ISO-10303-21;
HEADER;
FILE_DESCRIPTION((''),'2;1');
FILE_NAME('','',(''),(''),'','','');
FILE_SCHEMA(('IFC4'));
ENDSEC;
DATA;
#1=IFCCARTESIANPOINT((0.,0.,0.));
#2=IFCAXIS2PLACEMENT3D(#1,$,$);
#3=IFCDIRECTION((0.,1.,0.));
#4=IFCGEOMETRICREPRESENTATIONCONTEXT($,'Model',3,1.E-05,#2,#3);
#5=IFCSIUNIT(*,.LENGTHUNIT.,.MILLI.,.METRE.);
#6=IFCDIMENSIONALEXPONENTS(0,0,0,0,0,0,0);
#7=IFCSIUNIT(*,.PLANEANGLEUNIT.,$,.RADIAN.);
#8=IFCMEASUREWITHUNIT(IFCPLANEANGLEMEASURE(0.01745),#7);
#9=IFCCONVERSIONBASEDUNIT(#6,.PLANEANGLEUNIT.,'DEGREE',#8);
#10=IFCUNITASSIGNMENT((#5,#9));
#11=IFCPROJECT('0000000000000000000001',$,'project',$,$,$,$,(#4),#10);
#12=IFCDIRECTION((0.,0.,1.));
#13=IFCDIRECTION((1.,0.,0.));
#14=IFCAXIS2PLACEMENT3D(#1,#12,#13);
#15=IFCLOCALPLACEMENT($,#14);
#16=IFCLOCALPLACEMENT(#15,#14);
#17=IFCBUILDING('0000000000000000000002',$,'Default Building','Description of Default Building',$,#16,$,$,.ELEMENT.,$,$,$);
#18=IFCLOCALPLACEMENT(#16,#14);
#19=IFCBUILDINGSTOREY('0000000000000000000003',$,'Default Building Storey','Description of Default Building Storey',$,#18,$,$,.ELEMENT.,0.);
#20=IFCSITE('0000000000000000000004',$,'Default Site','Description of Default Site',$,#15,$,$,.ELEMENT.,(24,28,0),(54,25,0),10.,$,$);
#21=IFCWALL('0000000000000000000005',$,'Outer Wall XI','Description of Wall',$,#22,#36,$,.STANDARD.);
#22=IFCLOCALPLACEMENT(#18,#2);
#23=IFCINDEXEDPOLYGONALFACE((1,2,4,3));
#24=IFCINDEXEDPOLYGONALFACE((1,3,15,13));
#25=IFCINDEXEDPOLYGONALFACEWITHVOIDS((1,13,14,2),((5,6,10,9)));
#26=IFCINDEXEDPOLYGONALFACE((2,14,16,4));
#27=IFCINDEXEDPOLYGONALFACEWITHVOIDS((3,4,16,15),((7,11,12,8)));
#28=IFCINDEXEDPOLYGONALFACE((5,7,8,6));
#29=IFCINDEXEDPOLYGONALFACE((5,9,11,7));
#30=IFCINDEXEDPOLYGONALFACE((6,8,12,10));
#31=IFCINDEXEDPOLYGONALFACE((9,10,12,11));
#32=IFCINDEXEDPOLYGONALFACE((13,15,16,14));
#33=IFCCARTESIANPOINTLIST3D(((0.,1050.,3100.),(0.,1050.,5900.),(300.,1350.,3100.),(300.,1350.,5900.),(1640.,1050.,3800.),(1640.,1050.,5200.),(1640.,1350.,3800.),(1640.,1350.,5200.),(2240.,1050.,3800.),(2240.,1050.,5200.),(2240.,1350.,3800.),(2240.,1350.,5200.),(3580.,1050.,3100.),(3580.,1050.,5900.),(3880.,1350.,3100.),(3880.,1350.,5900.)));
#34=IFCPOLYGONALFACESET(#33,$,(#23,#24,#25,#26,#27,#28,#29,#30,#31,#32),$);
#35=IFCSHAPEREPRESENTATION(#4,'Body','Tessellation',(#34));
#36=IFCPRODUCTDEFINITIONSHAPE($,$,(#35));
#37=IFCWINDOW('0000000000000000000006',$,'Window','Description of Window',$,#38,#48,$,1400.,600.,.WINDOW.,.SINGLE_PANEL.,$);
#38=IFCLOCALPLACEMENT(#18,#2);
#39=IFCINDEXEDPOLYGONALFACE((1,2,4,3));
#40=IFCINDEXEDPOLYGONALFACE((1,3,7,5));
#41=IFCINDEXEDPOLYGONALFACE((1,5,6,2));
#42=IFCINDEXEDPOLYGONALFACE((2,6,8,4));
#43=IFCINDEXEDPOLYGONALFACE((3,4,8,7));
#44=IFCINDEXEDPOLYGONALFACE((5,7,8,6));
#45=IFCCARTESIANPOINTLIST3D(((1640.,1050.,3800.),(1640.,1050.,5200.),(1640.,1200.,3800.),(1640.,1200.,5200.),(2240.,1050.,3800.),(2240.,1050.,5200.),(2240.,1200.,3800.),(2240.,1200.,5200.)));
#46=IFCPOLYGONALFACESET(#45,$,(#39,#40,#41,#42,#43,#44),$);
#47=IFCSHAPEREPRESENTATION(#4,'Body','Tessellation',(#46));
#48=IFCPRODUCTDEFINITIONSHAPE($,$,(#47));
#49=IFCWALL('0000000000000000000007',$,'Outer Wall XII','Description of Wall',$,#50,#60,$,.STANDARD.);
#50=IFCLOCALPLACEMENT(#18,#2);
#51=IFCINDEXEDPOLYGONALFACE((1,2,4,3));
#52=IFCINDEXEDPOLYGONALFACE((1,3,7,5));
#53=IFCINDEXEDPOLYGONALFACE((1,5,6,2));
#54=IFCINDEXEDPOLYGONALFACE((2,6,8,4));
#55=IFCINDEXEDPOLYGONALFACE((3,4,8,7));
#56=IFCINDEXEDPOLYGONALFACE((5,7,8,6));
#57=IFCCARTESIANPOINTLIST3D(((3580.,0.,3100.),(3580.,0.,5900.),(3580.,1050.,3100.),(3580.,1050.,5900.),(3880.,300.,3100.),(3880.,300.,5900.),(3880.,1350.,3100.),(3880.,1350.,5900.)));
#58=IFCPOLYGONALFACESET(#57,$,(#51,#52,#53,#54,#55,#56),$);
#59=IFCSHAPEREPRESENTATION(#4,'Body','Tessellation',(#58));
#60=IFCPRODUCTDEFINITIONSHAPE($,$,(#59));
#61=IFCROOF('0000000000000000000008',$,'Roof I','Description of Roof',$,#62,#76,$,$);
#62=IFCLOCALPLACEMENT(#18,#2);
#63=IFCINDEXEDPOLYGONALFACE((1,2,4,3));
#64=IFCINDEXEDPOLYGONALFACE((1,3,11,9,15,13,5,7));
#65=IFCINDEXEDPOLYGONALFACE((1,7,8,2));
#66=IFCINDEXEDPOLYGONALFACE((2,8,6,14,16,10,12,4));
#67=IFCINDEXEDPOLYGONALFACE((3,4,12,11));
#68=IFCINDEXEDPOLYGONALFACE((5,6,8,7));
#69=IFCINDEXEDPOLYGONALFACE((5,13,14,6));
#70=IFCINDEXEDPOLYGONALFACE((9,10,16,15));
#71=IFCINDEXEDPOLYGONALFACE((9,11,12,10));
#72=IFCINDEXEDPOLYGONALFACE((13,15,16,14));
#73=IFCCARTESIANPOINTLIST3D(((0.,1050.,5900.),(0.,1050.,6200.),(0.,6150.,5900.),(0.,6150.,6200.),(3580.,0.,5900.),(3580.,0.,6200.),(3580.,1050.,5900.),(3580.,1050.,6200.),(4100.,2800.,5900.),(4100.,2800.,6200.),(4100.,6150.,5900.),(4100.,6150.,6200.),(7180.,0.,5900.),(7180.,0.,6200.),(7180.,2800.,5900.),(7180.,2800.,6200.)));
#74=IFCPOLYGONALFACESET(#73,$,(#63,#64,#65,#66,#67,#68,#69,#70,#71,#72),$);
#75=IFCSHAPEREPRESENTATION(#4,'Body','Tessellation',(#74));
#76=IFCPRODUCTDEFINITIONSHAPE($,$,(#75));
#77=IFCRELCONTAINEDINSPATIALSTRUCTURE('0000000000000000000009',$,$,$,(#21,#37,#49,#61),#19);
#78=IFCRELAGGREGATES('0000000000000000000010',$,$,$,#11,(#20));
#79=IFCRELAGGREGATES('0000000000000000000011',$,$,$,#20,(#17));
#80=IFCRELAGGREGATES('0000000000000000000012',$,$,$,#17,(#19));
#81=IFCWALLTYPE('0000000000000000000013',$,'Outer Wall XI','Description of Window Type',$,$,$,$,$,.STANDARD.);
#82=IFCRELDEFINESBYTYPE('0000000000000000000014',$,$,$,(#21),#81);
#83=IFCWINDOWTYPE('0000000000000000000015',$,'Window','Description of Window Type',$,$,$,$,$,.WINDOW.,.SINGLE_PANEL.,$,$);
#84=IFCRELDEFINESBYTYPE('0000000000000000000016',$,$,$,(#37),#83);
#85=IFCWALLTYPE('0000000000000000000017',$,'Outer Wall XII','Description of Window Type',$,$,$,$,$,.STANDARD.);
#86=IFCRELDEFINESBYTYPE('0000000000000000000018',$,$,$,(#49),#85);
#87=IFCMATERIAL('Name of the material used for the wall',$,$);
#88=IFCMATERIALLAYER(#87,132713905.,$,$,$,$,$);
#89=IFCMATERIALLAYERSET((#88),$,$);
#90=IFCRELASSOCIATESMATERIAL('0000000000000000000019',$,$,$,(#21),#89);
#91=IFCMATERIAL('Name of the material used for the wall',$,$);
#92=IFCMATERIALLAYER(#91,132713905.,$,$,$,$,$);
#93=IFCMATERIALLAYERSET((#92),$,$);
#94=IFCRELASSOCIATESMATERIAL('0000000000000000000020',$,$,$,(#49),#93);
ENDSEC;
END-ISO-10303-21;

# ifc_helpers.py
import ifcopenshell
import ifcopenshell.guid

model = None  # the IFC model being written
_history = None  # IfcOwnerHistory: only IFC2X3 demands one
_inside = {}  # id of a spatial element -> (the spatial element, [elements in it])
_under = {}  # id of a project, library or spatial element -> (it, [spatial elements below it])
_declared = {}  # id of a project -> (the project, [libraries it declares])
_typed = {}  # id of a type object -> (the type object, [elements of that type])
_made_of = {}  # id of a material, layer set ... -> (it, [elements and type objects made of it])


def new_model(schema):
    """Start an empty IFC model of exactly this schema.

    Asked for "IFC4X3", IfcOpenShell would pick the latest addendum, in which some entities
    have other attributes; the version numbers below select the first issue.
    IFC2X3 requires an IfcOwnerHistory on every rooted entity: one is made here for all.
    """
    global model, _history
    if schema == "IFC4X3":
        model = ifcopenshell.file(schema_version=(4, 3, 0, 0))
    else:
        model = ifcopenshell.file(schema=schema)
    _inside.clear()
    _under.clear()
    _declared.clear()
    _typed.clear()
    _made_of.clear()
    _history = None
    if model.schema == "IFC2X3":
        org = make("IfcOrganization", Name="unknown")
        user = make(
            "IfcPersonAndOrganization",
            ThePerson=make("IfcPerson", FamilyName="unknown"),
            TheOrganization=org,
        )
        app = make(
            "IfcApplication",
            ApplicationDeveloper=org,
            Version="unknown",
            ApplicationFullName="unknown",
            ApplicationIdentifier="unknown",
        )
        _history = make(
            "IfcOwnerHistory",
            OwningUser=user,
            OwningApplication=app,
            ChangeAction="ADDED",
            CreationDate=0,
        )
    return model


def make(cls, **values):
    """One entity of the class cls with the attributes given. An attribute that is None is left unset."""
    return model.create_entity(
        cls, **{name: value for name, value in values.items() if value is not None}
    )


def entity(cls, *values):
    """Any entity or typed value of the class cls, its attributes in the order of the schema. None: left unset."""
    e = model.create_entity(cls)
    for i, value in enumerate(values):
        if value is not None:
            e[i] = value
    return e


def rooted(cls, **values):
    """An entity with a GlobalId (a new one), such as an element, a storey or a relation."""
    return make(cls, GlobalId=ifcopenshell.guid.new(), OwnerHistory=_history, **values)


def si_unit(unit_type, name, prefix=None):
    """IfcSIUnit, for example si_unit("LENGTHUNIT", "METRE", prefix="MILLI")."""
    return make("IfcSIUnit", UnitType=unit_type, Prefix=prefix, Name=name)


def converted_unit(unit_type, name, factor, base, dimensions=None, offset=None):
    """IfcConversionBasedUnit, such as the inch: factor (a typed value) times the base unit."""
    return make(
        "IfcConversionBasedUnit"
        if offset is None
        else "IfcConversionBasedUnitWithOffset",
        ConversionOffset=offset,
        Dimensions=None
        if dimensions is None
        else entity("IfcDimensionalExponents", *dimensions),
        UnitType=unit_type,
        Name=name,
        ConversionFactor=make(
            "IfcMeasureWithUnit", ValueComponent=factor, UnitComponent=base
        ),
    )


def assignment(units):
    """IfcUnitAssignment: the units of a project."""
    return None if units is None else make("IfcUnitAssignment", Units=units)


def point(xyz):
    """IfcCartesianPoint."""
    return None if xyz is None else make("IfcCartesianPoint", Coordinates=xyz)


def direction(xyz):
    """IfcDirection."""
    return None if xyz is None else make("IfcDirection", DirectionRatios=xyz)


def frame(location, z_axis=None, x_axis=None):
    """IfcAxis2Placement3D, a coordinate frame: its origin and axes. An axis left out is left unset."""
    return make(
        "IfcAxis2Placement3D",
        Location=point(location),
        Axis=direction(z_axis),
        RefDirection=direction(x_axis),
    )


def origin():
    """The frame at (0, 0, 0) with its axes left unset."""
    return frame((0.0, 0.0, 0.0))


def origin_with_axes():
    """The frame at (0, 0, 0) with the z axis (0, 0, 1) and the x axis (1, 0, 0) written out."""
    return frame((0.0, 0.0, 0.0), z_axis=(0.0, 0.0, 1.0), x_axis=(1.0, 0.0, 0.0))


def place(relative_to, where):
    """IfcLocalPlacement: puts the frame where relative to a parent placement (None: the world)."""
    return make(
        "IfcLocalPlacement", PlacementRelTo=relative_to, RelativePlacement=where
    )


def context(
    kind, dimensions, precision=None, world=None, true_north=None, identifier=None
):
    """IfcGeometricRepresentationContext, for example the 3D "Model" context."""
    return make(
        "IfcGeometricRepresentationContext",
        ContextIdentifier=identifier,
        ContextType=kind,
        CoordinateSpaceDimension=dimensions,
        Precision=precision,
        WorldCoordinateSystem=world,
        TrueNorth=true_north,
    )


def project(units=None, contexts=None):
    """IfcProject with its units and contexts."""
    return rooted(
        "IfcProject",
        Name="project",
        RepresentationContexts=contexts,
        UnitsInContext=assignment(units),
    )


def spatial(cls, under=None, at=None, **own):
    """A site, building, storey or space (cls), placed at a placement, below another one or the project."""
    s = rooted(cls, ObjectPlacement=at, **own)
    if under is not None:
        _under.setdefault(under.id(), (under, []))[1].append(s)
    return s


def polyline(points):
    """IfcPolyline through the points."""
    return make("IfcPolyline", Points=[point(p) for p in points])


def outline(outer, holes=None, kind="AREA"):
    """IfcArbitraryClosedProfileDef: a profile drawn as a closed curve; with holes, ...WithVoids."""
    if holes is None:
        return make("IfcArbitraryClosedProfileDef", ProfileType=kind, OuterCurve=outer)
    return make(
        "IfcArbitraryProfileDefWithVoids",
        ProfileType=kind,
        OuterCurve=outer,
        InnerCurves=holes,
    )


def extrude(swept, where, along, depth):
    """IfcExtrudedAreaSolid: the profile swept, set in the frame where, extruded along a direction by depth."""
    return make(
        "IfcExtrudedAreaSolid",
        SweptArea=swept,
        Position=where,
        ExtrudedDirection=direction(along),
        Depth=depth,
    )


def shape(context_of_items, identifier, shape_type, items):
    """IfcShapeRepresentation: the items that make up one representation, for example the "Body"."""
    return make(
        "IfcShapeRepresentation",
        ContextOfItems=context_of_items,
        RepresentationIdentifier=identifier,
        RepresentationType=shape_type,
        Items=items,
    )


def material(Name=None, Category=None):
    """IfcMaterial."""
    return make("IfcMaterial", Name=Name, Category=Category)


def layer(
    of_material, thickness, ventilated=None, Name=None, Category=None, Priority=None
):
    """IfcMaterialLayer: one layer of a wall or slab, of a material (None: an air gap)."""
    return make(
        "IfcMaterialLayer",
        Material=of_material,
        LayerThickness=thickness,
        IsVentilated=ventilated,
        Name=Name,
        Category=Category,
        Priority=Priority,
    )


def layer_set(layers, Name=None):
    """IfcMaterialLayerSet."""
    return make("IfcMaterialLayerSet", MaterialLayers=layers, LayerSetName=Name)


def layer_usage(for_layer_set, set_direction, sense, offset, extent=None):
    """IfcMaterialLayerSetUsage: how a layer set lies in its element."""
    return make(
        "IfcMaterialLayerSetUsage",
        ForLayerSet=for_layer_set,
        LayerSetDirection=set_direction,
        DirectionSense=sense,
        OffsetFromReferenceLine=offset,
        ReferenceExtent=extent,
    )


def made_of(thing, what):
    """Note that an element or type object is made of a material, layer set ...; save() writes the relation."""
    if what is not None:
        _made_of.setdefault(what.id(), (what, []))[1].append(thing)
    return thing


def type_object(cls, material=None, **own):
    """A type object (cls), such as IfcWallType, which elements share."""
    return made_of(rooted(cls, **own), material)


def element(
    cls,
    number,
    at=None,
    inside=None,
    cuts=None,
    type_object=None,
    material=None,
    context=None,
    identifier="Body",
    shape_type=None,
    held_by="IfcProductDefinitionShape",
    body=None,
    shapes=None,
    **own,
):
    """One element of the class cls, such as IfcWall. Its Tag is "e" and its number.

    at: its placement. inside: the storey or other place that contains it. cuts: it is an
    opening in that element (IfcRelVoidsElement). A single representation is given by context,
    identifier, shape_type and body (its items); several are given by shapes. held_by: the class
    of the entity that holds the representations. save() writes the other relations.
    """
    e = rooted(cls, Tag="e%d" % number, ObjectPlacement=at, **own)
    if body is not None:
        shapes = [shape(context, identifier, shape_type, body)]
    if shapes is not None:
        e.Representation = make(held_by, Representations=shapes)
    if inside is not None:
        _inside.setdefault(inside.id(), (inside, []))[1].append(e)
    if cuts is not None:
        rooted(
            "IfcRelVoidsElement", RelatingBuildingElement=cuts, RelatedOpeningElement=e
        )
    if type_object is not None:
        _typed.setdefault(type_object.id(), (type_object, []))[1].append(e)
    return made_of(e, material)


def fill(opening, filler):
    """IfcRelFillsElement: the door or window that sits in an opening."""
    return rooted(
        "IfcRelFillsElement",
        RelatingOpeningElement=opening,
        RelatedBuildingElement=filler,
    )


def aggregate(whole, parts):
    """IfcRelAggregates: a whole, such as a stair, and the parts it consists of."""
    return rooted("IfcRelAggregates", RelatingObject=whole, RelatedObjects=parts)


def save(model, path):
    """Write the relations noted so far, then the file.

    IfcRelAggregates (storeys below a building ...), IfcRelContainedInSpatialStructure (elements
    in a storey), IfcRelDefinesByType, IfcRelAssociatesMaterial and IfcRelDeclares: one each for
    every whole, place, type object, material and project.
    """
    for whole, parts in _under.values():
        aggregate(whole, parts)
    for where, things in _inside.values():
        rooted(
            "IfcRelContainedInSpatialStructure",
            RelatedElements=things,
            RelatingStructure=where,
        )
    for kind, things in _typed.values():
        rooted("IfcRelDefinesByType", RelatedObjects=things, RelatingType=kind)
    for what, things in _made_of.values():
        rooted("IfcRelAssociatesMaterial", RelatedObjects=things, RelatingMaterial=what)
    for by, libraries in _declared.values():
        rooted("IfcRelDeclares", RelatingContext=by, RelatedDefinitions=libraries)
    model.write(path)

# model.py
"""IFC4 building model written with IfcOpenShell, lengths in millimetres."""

from ifc_helpers import new_model, entity, si_unit, converted_unit, direction, frame, origin, origin_with_axes, place, context, project, spatial, polyline, outline, extrude, material, layer, layer_set, layer_usage, type_object, element, fill, save


model = new_model("IFC4")

# Units and contexts
model_context = context("Model", 3, precision=1e-05, world=origin(), true_north=direction((0.0, 1.0, 0.0)))
ifc_project = project(units=[si_unit("LENGTHUNIT", "METRE", prefix="MILLI"), converted_unit("PLANEANGLEUNIT", "DEGREE", entity("IfcPlaneAngleMeasure", 0.01745), si_unit("PLANEANGLEUNIT", "RADIAN"), dimensions=[0, 0, 0, 0, 0, 0, 0])], contexts=[model_context])

# Site, building, storey
site_placement = place(None, origin_with_axes())
site = spatial("IfcSite", under=ifc_project, at=site_placement, Name="Default Site", Description="Description of Default Site", CompositionType="ELEMENT", RefLatitude=(24, 28, 0), RefLongitude=(54, 25, 0), RefElevation=10.0)
building_placement = place(site_placement, origin_with_axes())
building = spatial("IfcBuilding", under=site, at=building_placement, Name="Default Building", Description="Description of Default Building", CompositionType="ELEMENT")
storey_placement = place(building_placement, origin_with_axes())
storey = spatial("IfcBuildingStorey", under=building, at=storey_placement, Name="Default Building Storey", Description="Description of Default Building Storey", CompositionType="ELEMENT", Elevation=0.0)

# Wall, opening, window
ifc_material_1 = material(Name="Name of the material used for the wall")
ifc_layer_1 = layer(ifc_material_1, 132713905.0)
ifc_layer_set_1 = layer_set([ifc_layer_1])
ifc_layer_usage_1 = layer_usage(ifc_layer_set_1, "AXIS2", "POSITIVE", -66356952.5)
wall_type_1 = type_object("IfcWallType", Name="Outer Wall XI", Description="Description of Window Type", PredefinedType="STANDARD")
wall_1_placement = place(storey_placement, frame((150.0, 1200.0, 3100.0), z_axis=(0.0, 0.0, 1.0), x_axis=(1.0, 0.0, 0.0)))
wall_1 = element("IfcWall", 1, at=wall_1_placement, inside=storey, type_object=wall_type_1, material=ifc_layer_usage_1, Name="Outer Wall XI", Description="Description of Wall", PredefinedType="STANDARD", context=model_context, shape_type="SweptSolid", body=[
    extrude(outline(polyline([(-150.0, -150.0), (150.0, 150.0), (3730.0, 150.0), (3430.0, -150.0), (-150.0, -150.0)])), origin_with_axes(), (0.0, 0.0, 1.0), 2800.0),
])
opening_1_placement = place(wall_1_placement, frame((1490.0, -150.0, 700.0), z_axis=(0.0, 0.0, 1.0), x_axis=(1.0, 0.0, 0.0)))
opening_1 = element("IfcOpeningElement", 2, at=opening_1_placement, cuts=wall_1, context=model_context, shape_type="SweptSolid", body=[
    extrude(outline(polyline([(0.0, 0.0), (0.0, 300.0), (600.0, 300.0), (600.0, 0.0), (0.0, 0.0)])), origin_with_axes(), (0.0, 0.0, 1.0), 1400.0),
])
window_type_1 = type_object("IfcWindowType", Name="Window", Description="Description of Window Type", PartitioningType="SINGLE_PANEL", PredefinedType="WINDOW")
window_1_placement = place(opening_1_placement, origin_with_axes())
window_1 = element("IfcWindow", 3, at=window_1_placement, inside=storey, type_object=window_type_1, Name="Window", Description="Description of Window", OverallHeight=1400.0, OverallWidth=600.0, PartitioningType="SINGLE_PANEL", PredefinedType="WINDOW", context=model_context, shape_type="SweptSolid", body=[
    extrude(outline(polyline([(0.0, 0.0), (0.0, 150.0), (600.0, 150.0), (600.0, 0.0), (0.0, 0.0)])), origin_with_axes(), (0.0, 0.0, 1.0), 1400.0),
])
fill(opening_1, window_1)

# Wall
ifc_material_2 = material(Name="Name of the material used for the wall")
ifc_layer_2 = layer(ifc_material_2, 132713905.0)
ifc_layer_set_2 = layer_set([ifc_layer_2])
ifc_layer_usage_2 = layer_usage(ifc_layer_set_2, "AXIS2", "POSITIVE", -66356952.5)
wall_type_2 = type_object("IfcWallType", Name="Outer Wall XII", Description="Description of Window Type", PredefinedType="STANDARD")
wall_2_placement = place(storey_placement, frame((3730.0, 1200.0, 3100.0), z_axis=(0.0, 0.0, 1.0), x_axis=(0.0, -1.0, 0.0)))
element("IfcWall", 4, at=wall_2_placement, inside=storey, type_object=wall_type_2, material=ifc_layer_usage_2, Name="Outer Wall XII", Description="Description of Wall", PredefinedType="STANDARD", context=model_context, shape_type="SweptSolid", body=[
    extrude(outline(polyline([(150.0, -150.0), (-150.0, 150.0), (900.0, 150.0), (1200.0, -150.0), (150.0, -150.0)])), origin_with_axes(), (0.0, 0.0, 1.0), 2800.0),
])

# Roof
roof_placement = place(storey_placement, frame((0.0, 0.0, 5900.0), z_axis=(0.0, 0.0, 1.0), x_axis=(1.0, 0.0, 0.0)))
element("IfcRoof", 5, at=roof_placement, inside=storey, Name="Roof I", Description="Description of Roof", context=model_context, shape_type="SweptSolid", body=[
    extrude(outline(polyline([(0.0, 1050.0), (0.0, 6150.0), (4100.0, 6150.0), (4100.0, 2800.0), (7180.0, 2800.0), (7180.0, 0.0), (3580.0, 0.0), (3580.0, 1050.0), (0.0, 1050.0)])), origin_with_axes(), (0.0, 0.0, 1.0), 300.0),
])

save(model, "model.ifc")
